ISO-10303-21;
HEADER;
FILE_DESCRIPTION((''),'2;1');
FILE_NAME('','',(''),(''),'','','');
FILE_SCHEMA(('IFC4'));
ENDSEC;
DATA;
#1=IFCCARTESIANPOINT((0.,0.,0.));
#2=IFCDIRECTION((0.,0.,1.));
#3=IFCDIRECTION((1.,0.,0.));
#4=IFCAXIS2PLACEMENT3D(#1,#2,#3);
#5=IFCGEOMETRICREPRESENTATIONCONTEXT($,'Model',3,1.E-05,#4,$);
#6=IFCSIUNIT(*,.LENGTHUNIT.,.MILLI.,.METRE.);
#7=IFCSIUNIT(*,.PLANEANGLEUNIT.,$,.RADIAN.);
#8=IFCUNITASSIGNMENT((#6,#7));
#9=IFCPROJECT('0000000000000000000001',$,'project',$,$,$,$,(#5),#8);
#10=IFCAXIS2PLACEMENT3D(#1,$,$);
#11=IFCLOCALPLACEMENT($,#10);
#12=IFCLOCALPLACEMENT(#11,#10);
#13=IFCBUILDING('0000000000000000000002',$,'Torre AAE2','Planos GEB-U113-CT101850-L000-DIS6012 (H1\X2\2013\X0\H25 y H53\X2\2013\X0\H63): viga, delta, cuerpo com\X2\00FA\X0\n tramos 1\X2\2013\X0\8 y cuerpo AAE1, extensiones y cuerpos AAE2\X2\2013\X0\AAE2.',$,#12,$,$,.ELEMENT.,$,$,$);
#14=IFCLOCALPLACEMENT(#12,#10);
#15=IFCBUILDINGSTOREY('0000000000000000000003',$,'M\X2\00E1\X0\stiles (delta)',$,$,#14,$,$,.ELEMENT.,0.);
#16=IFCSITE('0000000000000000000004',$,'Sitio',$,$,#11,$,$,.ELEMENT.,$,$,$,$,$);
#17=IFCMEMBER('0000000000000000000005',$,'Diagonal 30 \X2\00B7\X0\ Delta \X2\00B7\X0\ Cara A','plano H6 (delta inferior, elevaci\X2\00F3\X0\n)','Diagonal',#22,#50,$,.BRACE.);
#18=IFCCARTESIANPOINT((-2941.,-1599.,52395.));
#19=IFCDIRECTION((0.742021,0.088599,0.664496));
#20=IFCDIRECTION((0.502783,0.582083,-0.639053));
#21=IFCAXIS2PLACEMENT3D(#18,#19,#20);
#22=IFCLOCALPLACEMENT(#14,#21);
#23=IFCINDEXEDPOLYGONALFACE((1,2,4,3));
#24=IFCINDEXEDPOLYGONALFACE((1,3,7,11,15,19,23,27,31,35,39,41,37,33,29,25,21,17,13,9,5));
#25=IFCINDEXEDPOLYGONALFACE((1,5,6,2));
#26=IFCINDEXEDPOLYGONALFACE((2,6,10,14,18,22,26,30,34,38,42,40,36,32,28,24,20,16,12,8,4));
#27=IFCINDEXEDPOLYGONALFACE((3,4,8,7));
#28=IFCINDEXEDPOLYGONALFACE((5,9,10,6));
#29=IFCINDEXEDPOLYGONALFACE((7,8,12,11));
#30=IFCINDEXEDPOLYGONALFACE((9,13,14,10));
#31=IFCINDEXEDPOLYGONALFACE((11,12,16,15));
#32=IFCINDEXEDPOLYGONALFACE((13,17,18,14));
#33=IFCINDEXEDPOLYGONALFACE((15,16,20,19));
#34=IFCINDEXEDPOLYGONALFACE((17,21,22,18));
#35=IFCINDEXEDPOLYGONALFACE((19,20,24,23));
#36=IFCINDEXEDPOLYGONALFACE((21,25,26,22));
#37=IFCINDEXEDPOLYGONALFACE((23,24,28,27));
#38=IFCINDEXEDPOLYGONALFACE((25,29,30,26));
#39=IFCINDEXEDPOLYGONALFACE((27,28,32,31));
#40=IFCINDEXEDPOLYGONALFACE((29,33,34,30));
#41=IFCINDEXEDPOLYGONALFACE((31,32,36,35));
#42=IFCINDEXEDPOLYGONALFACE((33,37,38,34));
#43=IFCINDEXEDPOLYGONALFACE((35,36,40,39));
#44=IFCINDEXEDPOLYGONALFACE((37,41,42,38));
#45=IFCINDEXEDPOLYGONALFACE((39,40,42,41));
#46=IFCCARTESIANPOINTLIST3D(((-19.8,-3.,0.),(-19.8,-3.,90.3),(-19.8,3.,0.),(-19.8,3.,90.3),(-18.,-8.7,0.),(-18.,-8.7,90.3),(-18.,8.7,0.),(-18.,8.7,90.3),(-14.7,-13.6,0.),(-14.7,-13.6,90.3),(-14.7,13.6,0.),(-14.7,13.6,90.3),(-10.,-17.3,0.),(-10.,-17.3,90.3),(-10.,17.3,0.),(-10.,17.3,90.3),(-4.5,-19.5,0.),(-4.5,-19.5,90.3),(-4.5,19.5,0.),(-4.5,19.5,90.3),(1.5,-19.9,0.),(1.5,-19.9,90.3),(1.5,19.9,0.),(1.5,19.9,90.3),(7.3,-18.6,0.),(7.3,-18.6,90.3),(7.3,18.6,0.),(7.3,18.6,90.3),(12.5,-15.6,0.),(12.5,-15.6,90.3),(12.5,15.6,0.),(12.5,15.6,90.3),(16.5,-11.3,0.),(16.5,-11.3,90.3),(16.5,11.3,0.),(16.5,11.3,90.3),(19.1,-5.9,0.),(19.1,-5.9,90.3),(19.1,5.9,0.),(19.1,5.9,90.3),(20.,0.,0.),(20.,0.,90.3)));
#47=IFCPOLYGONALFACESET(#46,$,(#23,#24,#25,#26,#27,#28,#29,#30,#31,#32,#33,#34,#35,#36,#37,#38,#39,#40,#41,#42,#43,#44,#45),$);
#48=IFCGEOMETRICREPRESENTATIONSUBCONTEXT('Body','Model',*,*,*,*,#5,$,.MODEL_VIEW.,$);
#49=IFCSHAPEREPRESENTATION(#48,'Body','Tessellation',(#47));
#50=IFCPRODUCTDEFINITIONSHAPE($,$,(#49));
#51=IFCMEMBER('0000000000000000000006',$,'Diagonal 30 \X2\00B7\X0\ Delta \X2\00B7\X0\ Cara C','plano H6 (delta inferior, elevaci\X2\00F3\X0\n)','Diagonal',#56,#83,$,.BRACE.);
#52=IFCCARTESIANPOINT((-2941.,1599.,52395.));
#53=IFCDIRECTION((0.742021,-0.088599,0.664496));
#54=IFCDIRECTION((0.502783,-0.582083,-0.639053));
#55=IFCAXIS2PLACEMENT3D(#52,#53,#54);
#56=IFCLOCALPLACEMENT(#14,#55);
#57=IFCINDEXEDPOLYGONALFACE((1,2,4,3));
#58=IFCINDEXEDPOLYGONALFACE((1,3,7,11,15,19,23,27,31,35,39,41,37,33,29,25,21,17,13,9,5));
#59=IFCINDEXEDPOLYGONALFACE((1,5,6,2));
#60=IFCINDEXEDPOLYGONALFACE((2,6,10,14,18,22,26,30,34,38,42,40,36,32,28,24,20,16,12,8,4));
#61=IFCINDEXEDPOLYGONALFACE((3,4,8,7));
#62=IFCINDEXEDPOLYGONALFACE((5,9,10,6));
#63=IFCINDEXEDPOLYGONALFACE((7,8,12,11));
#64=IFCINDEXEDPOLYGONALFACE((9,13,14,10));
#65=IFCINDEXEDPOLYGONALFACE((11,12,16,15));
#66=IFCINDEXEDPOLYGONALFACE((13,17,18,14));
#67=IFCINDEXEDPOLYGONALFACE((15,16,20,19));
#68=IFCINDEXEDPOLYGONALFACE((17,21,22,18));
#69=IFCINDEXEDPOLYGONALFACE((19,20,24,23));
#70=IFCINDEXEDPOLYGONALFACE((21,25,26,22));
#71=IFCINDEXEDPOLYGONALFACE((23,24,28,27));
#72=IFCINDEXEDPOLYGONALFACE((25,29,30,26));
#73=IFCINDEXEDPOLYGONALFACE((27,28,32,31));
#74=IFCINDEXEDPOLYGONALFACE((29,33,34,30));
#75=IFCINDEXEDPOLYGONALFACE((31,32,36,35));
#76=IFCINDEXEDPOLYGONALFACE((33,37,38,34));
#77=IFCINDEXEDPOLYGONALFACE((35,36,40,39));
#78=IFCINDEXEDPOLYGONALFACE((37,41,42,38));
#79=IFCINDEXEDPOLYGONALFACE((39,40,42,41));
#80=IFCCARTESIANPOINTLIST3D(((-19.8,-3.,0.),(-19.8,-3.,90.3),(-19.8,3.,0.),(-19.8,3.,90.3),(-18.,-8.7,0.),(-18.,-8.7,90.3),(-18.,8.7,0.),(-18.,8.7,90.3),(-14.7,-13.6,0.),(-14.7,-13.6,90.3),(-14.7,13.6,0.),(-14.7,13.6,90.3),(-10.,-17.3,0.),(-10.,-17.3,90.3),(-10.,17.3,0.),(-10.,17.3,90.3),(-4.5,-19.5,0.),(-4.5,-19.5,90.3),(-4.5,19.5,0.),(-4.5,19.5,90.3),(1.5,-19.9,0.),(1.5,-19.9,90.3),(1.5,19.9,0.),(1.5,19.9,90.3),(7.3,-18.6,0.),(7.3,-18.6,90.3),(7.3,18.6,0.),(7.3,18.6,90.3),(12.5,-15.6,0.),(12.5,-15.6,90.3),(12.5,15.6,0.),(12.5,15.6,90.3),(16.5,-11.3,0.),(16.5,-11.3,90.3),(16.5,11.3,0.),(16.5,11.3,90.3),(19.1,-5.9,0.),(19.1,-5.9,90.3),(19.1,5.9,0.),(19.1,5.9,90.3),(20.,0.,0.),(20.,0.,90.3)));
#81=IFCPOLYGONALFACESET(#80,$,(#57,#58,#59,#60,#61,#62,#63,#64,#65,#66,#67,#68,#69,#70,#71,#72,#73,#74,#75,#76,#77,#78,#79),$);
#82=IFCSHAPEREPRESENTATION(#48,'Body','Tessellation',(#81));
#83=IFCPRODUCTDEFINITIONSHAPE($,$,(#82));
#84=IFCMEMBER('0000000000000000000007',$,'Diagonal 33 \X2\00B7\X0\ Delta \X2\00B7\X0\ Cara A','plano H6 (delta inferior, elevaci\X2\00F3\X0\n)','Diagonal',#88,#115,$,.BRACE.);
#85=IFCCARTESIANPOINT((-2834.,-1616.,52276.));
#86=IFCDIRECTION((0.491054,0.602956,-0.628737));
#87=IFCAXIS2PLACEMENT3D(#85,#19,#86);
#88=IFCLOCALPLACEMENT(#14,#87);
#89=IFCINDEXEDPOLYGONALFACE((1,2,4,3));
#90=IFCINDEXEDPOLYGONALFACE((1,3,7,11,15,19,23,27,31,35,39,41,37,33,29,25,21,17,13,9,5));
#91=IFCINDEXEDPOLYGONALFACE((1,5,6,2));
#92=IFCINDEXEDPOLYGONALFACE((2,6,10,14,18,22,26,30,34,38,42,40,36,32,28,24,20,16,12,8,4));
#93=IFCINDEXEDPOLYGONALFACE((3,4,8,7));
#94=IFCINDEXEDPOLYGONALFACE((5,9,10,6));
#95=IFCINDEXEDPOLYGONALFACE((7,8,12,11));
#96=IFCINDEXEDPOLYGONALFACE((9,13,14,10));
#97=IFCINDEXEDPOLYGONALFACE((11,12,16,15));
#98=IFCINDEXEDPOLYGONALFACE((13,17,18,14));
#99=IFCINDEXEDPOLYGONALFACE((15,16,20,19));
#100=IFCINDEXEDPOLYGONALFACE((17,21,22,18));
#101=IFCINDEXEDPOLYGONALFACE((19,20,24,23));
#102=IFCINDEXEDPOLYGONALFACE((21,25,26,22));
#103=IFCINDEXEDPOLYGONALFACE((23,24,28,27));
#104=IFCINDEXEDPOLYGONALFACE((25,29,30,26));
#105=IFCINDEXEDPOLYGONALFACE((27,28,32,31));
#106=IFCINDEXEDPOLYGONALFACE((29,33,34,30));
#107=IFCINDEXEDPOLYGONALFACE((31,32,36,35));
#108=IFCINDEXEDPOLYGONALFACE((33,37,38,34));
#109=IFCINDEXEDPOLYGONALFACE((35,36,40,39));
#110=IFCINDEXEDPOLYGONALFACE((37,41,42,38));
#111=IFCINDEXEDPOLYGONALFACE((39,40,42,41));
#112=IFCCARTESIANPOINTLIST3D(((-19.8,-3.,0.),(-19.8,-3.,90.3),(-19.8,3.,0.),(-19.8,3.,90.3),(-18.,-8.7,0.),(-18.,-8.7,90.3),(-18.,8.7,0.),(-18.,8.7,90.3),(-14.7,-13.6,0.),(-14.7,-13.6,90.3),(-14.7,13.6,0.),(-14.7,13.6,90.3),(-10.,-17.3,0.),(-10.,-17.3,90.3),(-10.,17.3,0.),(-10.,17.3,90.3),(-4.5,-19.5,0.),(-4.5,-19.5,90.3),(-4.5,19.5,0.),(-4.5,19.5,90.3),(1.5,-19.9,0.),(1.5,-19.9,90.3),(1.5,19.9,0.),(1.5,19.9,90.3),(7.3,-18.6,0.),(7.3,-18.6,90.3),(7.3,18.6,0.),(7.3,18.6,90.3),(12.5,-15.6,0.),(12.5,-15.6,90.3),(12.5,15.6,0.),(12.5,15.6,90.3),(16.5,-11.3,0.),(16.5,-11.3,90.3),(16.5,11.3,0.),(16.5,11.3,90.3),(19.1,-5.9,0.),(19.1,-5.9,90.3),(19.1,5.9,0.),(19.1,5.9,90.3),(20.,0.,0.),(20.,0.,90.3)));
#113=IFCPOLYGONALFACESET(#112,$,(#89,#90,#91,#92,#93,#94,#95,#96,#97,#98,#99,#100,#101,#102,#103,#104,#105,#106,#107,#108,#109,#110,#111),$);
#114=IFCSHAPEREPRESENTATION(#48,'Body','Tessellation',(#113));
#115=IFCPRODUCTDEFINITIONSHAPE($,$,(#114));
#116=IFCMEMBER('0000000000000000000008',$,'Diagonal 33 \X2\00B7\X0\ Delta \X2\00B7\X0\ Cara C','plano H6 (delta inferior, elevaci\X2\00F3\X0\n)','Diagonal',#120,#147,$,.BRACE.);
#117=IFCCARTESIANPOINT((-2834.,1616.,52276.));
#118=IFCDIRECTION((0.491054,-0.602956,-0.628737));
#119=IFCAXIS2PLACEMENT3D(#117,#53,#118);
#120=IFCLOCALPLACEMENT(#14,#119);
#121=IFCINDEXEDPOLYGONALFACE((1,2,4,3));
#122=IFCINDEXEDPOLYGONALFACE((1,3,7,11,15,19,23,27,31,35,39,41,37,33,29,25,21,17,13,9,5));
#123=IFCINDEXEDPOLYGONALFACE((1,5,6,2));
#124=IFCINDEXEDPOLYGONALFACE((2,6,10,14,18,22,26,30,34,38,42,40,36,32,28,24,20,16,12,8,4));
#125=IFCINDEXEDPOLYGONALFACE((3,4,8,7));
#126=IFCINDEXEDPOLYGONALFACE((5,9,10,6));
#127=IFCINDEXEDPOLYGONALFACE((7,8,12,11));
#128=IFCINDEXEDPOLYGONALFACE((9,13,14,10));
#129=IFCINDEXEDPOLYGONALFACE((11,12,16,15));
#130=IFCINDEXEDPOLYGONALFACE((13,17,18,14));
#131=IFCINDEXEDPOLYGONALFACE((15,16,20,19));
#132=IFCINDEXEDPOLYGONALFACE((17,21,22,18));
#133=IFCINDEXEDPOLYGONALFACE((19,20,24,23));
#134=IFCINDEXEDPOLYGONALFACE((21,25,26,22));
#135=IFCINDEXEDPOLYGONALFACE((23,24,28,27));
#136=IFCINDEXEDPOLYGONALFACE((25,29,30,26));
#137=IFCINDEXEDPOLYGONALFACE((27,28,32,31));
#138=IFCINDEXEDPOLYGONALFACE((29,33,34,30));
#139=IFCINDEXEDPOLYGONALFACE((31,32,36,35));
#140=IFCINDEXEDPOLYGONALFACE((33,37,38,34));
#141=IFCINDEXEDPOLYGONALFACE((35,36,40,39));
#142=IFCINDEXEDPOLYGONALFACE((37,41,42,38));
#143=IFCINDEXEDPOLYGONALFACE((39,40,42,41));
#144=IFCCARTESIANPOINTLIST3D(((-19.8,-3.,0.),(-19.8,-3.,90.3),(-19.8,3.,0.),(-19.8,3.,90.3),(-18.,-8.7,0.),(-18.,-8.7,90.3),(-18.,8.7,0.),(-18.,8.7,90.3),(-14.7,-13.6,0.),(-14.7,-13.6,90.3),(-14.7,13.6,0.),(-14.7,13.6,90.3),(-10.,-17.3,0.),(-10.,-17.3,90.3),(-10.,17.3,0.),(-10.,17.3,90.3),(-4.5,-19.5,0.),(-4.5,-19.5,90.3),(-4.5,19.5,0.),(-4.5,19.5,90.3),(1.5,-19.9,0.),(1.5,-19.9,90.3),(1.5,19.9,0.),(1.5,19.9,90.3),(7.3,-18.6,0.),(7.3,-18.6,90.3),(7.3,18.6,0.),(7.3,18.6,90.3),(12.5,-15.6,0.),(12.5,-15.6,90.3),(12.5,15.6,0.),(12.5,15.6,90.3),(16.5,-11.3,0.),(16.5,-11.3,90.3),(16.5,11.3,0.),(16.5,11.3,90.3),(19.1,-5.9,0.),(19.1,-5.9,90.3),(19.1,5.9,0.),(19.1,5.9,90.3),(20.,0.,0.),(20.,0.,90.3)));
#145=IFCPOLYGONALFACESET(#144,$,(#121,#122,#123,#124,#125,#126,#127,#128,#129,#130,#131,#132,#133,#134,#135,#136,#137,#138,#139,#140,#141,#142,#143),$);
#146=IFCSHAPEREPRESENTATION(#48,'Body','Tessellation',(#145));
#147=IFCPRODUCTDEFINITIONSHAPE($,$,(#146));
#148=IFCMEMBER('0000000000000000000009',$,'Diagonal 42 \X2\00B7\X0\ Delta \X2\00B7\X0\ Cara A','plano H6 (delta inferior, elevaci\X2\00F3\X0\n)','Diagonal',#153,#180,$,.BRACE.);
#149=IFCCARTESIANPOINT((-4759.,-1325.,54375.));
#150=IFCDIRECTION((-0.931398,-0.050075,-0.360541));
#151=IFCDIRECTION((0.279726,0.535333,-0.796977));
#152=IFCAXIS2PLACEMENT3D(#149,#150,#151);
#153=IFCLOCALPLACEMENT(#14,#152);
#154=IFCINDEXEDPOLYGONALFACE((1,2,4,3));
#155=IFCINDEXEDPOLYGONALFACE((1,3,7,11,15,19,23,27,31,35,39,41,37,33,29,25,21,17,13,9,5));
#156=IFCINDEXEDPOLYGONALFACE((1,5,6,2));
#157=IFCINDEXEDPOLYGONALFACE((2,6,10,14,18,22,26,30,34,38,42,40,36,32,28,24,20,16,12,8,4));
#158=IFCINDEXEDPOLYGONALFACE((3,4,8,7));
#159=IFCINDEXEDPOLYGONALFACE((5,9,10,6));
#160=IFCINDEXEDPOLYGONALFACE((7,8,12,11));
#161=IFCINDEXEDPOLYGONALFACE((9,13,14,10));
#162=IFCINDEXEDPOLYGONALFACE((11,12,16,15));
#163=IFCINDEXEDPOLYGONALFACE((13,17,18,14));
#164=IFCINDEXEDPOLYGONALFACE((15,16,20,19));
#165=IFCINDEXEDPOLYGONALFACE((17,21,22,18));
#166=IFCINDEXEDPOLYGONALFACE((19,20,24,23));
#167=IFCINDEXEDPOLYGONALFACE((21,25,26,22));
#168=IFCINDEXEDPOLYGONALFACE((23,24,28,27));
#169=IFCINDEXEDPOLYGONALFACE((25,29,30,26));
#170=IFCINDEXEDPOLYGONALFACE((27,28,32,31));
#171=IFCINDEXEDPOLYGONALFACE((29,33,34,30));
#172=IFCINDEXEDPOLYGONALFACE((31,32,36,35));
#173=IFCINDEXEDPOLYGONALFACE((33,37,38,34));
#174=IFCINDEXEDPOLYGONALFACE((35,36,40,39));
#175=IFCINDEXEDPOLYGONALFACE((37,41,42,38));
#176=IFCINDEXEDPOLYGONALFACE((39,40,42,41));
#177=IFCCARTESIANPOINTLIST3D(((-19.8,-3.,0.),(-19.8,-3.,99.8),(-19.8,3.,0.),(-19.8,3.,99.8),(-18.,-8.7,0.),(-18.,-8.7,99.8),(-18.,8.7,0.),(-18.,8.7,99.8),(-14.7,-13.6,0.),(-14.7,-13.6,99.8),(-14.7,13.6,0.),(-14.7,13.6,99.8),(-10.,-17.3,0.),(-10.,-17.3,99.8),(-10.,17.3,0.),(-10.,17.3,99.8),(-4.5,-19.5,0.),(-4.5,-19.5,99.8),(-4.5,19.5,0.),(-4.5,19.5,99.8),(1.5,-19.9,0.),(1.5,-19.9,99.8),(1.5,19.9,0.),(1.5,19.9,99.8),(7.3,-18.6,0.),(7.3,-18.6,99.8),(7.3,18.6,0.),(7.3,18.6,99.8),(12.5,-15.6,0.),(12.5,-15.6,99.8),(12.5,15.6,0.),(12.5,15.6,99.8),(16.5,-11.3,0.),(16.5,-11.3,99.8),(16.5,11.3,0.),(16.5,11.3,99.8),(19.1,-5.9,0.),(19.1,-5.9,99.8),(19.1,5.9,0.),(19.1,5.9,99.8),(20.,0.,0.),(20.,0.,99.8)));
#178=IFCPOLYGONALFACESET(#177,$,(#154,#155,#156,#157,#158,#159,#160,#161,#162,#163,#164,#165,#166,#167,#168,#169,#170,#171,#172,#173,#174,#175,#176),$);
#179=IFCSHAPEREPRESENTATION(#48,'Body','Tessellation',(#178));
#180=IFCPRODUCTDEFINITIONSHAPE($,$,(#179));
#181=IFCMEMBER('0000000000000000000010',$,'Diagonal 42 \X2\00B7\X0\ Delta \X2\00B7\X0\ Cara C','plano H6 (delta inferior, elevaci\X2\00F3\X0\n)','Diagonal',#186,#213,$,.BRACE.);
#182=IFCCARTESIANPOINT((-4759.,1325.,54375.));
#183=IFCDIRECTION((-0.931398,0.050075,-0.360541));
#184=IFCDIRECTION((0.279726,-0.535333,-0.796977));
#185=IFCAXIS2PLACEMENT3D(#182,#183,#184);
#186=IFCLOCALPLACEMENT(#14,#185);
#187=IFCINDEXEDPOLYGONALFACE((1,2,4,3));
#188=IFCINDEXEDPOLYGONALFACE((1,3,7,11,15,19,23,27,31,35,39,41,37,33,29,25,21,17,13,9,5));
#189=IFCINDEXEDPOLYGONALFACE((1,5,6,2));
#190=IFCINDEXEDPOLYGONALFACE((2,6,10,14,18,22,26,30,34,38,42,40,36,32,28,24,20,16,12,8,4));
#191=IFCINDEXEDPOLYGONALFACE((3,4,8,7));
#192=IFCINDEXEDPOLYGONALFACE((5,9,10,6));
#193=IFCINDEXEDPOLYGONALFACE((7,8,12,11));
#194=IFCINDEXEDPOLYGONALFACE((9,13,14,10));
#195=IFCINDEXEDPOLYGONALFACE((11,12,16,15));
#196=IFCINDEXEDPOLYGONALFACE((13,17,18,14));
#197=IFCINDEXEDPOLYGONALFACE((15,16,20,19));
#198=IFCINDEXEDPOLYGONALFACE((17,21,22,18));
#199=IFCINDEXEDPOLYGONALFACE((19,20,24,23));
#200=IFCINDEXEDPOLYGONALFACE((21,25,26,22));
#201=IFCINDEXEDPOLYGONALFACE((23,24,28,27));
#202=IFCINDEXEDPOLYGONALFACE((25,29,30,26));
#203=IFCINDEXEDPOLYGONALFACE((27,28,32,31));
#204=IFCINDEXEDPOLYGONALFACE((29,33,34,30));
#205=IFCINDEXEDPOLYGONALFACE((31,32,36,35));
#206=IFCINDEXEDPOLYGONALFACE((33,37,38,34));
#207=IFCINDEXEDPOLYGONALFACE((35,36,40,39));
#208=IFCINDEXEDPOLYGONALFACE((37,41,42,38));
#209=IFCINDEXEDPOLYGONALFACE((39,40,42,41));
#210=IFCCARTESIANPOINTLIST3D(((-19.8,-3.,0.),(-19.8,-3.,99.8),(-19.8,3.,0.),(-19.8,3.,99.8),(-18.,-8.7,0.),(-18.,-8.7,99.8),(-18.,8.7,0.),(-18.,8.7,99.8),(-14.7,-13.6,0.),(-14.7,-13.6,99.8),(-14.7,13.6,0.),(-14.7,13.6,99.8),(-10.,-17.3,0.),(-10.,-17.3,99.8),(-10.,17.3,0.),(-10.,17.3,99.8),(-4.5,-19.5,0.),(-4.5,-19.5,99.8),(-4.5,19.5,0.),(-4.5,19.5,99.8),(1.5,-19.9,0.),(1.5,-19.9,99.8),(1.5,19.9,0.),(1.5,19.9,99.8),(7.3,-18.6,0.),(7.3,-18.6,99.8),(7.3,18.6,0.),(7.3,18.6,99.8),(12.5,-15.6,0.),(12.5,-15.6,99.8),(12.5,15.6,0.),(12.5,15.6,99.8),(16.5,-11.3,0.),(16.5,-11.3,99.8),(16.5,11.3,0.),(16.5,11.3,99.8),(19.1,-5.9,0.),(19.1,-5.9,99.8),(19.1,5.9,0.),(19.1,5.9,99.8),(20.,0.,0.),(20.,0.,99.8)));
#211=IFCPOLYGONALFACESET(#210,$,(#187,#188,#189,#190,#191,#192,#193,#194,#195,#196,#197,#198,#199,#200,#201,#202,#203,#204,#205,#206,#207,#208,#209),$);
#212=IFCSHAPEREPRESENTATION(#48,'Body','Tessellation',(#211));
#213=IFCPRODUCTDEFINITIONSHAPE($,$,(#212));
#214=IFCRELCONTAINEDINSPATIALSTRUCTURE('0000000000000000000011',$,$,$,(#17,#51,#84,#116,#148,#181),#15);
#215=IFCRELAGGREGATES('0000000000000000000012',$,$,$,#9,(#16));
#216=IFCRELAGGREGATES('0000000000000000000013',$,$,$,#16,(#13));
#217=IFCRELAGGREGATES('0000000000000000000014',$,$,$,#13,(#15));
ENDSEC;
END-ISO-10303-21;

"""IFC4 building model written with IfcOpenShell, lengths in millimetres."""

from ifc_helpers import new_model, si_unit, frame, origin, origin_with_axes, place, context, subcontext, project, spatial, circle, extrude, element, save


model = new_model("IFC4")

# Units and contexts
model_context = context("Model", 3, precision=1e-05, world=origin_with_axes())
body_context = subcontext(model_context, "Body", "Model", "MODEL_VIEW")
ifc_project = project(units=[si_unit("LENGTHUNIT", "METRE", prefix="MILLI"), si_unit("PLANEANGLEUNIT", "RADIAN")], contexts=[model_context])

# Site, building, storey
site_placement = place(None, origin())
site = spatial("IfcSite", under=ifc_project, at=site_placement, Name="Sitio", CompositionType="ELEMENT")
building_placement = place(site_placement, origin())
building = spatial("IfcBuilding", under=site, at=building_placement, Name="Torre AAE2", Description="Planos GEB-U113-CT101850-L000-DIS6012 (H1–H25 y H53–H63): viga, delta, cuerpo común tramos 1–8 y cuerpo AAE1, extensiones y cuerpos AAE2–AAE2.", CompositionType="ELEMENT")
storey_placement = place(building_placement, origin())
storey = spatial("IfcBuildingStorey", under=building, at=storey_placement, Name="Mástiles (delta)", CompositionType="ELEMENT", Elevation=0.0)

# Members
for number, where, z_axis, x_axis, name in (
    (1, (-2941.0, -1599.0, 52395.0), (0.742021, 0.088599, 0.664496), (0.502783, 0.582083, -0.639053), "Diagonal 30 · Delta · Cara A"),
    (2, (-2941.0, 1599.0, 52395.0), (0.742021, -0.088599, 0.664496), (0.502783, -0.582083, -0.639053), "Diagonal 30 · Delta · Cara C"),
):
    element("IfcMember", number, at=place(storey_placement, frame(where, z_axis=z_axis, x_axis=x_axis)), inside=storey, Name=name, Description="plano H6 (delta inferior, elevación)", ObjectType="Diagonal", PredefinedType="BRACE", context=body_context, shape_type="SweptSolid", body=[
        extrude(circle(Radius=20.0), None, (0.0, 0.0, 1.0), 90.3),
    ])
for number, where, z_axis, x_axis, name in (
    (3, (-2834.0, -1616.0, 52276.0), (0.742021, 0.088599, 0.664496), (0.491054, 0.602956, -0.628737), "Diagonal 33 · Delta · Cara A"),
    (4, (-2834.0, 1616.0, 52276.0), (0.742021, -0.088599, 0.664496), (0.491054, -0.602956, -0.628737), "Diagonal 33 · Delta · Cara C"),
):
    element("IfcMember", number, at=place(storey_placement, frame(where, z_axis=z_axis, x_axis=x_axis)), inside=storey, Name=name, Description="plano H6 (delta inferior, elevación)", ObjectType="Diagonal", PredefinedType="BRACE", context=body_context, shape_type="SweptSolid", body=[
        extrude(circle(Radius=20.0), None, (0.0, 0.0, 1.0), 90.3),
    ])
for number, where, z_axis, x_axis, name in (
    (5, (-4759.0, -1325.0, 54375.0), (-0.931398, -0.050075, -0.360541), (0.279726, 0.535333, -0.796977), "Diagonal 42 · Delta · Cara A"),
    (6, (-4759.0, 1325.0, 54375.0), (-0.931398, 0.050075, -0.360541), (0.279726, -0.535333, -0.796977), "Diagonal 42 · Delta · Cara C"),
):
    element("IfcMember", number, at=place(storey_placement, frame(where, z_axis=z_axis, x_axis=x_axis)), inside=storey, Name=name, Description="plano H6 (delta inferior, elevación)", ObjectType="Diagonal", PredefinedType="BRACE", context=body_context, shape_type="SweptSolid", body=[
        extrude(circle(Radius=20.0), None, (0.0, 0.0, 1.0), 99.8),
    ])

save(model, "model.ifc")
